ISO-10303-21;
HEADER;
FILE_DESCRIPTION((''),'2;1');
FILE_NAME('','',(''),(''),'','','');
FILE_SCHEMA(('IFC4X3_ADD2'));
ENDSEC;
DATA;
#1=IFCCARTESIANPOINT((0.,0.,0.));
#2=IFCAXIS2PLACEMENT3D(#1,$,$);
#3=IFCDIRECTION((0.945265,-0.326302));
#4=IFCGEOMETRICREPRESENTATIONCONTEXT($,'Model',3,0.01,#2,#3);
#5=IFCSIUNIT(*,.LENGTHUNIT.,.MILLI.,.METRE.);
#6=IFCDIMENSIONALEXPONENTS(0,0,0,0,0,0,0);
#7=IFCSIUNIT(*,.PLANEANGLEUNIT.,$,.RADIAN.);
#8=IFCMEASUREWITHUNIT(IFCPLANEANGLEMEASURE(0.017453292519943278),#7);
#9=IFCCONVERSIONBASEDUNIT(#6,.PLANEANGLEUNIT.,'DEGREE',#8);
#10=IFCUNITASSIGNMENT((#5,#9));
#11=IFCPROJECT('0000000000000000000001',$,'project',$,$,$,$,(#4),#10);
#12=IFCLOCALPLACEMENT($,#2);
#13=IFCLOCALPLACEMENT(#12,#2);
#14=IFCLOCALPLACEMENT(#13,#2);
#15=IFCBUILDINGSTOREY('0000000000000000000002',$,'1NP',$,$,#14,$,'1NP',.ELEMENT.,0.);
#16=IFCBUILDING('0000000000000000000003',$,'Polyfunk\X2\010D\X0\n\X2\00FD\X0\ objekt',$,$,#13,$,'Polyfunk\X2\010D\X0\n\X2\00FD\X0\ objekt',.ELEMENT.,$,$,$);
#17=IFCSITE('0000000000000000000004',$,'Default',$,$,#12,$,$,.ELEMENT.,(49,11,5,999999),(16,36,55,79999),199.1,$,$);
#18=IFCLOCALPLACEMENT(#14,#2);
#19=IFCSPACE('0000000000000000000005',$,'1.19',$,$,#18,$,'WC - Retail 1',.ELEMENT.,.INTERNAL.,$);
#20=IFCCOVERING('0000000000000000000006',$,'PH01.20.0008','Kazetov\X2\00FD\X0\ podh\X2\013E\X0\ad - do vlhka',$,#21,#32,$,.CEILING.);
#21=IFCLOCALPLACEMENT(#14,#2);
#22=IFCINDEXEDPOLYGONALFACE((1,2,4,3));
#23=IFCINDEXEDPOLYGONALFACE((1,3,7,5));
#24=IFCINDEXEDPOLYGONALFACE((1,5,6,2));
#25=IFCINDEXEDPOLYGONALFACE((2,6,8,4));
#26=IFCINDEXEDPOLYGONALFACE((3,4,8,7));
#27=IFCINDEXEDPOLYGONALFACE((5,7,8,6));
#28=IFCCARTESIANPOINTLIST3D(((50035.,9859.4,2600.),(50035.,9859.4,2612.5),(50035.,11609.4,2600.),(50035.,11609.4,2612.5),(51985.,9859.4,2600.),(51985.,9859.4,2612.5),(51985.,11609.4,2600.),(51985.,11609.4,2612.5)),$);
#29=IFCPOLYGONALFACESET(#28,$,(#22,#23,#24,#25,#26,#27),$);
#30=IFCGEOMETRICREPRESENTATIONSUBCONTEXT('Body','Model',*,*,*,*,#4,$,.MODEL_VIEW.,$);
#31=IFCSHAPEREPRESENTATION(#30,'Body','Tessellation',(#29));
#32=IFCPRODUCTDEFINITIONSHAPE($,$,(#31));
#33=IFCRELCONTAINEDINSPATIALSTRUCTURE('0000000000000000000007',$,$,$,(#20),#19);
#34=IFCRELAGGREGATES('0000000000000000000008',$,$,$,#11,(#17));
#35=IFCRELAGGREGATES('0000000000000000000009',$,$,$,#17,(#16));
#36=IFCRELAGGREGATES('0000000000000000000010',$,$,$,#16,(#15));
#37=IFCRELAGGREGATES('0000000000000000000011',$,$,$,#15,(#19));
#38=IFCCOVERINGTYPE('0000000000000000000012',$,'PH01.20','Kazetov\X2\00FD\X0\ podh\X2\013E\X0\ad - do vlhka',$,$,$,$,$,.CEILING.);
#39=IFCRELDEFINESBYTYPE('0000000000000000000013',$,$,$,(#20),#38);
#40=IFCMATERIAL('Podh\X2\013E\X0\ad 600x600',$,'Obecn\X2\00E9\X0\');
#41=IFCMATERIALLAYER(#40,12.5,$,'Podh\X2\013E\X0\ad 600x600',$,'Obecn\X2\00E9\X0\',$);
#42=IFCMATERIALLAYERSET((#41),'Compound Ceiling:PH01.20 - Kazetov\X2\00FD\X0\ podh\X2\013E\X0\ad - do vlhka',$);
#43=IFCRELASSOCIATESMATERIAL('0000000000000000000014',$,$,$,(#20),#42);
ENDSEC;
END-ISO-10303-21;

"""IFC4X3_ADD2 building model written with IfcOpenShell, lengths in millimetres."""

from ifc_helpers import new_model, entity, si_unit, converted_unit, direction, frame, origin, origin_2d_with_axis, place, context, subcontext, project, spatial, rectangle, extrude, material, layer, layer_set, layer_usage, type_object, element, save


model = new_model("IFC4X3_ADD2")

# Units and contexts
model_context = context("Model", 3, precision=0.01, world=origin(), true_north=direction((0.945265, -0.326302)))
body_context = subcontext(model_context, "Body", "Model", "MODEL_VIEW")
ifc_project = project(units=[si_unit("LENGTHUNIT", "METRE", prefix="MILLI"), converted_unit("PLANEANGLEUNIT", "DEGREE", entity("IfcPlaneAngleMeasure", 0.017453292519943278), si_unit("PLANEANGLEUNIT", "RADIAN"), dimensions=[0, 0, 0, 0, 0, 0, 0])], contexts=[model_context])

# Site, building, storey
site_placement = place(None, origin())
site = spatial("IfcSite", under=ifc_project, at=site_placement, Name="Default", CompositionType="ELEMENT", RefLatitude=(49, 11, 5, 999999), RefLongitude=(16, 36, 55, 79999), RefElevation=199.1)
building_placement = place(site_placement, origin())
building = spatial("IfcBuilding", under=site, at=building_placement, Name="Polyfunkčný objekt", LongName="Polyfunkčný objekt", CompositionType="ELEMENT")
storey_placement = place(building_placement, origin())
storey = spatial("IfcBuildingStorey", under=building, at=storey_placement, Name="1NP", LongName="1NP", CompositionType="ELEMENT", Elevation=0.0)

# Shared definitions
ifc_material_1 = material(Name="Podhľad 600x600", Category="Obecné")

# Shared definitions
space_1_placement = place(storey_placement, origin())
space_1 = spatial("IfcSpace", under=storey, at=space_1_placement, Name="1.19", LongName="WC - Retail 1", CompositionType="ELEMENT", PredefinedType="INTERNAL")

# Covering
ifc_layer_1 = layer(ifc_material_1, 12.5, Name="Podhľad 600x600", Category="Obecné")
ifc_layer_set_1 = layer_set([ifc_layer_1], Name="Compound Ceiling:PH01.20 - Kazetový podhľad - do vlhka")
ifc_layer_usage_1 = layer_usage(ifc_layer_set_1, "AXIS3", "NEGATIVE", 0.0)
covering_type_1 = type_object("IfcCoveringType", Name="PH01.20", Description="Kazetový podhľad - do vlhka", PredefinedType="CEILING")
covering_1_placement = place(storey_placement, frame((50035.0, 9859.4, 2600.0)))
element("IfcCovering", 1, at=covering_1_placement, inside=space_1, type_object=covering_type_1, material=ifc_layer_usage_1, Name="PH01.20.0008", Description="Kazetový podhľad - do vlhka", PredefinedType="CEILING", context=body_context, shape_type="SweptSolid", body=[
    extrude(rectangle(XDim=1950.0, YDim=1750.0, at=origin_2d_with_axis()), frame((975.0, 875.0, 0.0), z_axis=(0.0, 0.0, 1.0), x_axis=(-1.0, 0.0, 0.0)), (0.0, 0.0, 1.0), 12.5),
])

save(model, "model.ifc")
